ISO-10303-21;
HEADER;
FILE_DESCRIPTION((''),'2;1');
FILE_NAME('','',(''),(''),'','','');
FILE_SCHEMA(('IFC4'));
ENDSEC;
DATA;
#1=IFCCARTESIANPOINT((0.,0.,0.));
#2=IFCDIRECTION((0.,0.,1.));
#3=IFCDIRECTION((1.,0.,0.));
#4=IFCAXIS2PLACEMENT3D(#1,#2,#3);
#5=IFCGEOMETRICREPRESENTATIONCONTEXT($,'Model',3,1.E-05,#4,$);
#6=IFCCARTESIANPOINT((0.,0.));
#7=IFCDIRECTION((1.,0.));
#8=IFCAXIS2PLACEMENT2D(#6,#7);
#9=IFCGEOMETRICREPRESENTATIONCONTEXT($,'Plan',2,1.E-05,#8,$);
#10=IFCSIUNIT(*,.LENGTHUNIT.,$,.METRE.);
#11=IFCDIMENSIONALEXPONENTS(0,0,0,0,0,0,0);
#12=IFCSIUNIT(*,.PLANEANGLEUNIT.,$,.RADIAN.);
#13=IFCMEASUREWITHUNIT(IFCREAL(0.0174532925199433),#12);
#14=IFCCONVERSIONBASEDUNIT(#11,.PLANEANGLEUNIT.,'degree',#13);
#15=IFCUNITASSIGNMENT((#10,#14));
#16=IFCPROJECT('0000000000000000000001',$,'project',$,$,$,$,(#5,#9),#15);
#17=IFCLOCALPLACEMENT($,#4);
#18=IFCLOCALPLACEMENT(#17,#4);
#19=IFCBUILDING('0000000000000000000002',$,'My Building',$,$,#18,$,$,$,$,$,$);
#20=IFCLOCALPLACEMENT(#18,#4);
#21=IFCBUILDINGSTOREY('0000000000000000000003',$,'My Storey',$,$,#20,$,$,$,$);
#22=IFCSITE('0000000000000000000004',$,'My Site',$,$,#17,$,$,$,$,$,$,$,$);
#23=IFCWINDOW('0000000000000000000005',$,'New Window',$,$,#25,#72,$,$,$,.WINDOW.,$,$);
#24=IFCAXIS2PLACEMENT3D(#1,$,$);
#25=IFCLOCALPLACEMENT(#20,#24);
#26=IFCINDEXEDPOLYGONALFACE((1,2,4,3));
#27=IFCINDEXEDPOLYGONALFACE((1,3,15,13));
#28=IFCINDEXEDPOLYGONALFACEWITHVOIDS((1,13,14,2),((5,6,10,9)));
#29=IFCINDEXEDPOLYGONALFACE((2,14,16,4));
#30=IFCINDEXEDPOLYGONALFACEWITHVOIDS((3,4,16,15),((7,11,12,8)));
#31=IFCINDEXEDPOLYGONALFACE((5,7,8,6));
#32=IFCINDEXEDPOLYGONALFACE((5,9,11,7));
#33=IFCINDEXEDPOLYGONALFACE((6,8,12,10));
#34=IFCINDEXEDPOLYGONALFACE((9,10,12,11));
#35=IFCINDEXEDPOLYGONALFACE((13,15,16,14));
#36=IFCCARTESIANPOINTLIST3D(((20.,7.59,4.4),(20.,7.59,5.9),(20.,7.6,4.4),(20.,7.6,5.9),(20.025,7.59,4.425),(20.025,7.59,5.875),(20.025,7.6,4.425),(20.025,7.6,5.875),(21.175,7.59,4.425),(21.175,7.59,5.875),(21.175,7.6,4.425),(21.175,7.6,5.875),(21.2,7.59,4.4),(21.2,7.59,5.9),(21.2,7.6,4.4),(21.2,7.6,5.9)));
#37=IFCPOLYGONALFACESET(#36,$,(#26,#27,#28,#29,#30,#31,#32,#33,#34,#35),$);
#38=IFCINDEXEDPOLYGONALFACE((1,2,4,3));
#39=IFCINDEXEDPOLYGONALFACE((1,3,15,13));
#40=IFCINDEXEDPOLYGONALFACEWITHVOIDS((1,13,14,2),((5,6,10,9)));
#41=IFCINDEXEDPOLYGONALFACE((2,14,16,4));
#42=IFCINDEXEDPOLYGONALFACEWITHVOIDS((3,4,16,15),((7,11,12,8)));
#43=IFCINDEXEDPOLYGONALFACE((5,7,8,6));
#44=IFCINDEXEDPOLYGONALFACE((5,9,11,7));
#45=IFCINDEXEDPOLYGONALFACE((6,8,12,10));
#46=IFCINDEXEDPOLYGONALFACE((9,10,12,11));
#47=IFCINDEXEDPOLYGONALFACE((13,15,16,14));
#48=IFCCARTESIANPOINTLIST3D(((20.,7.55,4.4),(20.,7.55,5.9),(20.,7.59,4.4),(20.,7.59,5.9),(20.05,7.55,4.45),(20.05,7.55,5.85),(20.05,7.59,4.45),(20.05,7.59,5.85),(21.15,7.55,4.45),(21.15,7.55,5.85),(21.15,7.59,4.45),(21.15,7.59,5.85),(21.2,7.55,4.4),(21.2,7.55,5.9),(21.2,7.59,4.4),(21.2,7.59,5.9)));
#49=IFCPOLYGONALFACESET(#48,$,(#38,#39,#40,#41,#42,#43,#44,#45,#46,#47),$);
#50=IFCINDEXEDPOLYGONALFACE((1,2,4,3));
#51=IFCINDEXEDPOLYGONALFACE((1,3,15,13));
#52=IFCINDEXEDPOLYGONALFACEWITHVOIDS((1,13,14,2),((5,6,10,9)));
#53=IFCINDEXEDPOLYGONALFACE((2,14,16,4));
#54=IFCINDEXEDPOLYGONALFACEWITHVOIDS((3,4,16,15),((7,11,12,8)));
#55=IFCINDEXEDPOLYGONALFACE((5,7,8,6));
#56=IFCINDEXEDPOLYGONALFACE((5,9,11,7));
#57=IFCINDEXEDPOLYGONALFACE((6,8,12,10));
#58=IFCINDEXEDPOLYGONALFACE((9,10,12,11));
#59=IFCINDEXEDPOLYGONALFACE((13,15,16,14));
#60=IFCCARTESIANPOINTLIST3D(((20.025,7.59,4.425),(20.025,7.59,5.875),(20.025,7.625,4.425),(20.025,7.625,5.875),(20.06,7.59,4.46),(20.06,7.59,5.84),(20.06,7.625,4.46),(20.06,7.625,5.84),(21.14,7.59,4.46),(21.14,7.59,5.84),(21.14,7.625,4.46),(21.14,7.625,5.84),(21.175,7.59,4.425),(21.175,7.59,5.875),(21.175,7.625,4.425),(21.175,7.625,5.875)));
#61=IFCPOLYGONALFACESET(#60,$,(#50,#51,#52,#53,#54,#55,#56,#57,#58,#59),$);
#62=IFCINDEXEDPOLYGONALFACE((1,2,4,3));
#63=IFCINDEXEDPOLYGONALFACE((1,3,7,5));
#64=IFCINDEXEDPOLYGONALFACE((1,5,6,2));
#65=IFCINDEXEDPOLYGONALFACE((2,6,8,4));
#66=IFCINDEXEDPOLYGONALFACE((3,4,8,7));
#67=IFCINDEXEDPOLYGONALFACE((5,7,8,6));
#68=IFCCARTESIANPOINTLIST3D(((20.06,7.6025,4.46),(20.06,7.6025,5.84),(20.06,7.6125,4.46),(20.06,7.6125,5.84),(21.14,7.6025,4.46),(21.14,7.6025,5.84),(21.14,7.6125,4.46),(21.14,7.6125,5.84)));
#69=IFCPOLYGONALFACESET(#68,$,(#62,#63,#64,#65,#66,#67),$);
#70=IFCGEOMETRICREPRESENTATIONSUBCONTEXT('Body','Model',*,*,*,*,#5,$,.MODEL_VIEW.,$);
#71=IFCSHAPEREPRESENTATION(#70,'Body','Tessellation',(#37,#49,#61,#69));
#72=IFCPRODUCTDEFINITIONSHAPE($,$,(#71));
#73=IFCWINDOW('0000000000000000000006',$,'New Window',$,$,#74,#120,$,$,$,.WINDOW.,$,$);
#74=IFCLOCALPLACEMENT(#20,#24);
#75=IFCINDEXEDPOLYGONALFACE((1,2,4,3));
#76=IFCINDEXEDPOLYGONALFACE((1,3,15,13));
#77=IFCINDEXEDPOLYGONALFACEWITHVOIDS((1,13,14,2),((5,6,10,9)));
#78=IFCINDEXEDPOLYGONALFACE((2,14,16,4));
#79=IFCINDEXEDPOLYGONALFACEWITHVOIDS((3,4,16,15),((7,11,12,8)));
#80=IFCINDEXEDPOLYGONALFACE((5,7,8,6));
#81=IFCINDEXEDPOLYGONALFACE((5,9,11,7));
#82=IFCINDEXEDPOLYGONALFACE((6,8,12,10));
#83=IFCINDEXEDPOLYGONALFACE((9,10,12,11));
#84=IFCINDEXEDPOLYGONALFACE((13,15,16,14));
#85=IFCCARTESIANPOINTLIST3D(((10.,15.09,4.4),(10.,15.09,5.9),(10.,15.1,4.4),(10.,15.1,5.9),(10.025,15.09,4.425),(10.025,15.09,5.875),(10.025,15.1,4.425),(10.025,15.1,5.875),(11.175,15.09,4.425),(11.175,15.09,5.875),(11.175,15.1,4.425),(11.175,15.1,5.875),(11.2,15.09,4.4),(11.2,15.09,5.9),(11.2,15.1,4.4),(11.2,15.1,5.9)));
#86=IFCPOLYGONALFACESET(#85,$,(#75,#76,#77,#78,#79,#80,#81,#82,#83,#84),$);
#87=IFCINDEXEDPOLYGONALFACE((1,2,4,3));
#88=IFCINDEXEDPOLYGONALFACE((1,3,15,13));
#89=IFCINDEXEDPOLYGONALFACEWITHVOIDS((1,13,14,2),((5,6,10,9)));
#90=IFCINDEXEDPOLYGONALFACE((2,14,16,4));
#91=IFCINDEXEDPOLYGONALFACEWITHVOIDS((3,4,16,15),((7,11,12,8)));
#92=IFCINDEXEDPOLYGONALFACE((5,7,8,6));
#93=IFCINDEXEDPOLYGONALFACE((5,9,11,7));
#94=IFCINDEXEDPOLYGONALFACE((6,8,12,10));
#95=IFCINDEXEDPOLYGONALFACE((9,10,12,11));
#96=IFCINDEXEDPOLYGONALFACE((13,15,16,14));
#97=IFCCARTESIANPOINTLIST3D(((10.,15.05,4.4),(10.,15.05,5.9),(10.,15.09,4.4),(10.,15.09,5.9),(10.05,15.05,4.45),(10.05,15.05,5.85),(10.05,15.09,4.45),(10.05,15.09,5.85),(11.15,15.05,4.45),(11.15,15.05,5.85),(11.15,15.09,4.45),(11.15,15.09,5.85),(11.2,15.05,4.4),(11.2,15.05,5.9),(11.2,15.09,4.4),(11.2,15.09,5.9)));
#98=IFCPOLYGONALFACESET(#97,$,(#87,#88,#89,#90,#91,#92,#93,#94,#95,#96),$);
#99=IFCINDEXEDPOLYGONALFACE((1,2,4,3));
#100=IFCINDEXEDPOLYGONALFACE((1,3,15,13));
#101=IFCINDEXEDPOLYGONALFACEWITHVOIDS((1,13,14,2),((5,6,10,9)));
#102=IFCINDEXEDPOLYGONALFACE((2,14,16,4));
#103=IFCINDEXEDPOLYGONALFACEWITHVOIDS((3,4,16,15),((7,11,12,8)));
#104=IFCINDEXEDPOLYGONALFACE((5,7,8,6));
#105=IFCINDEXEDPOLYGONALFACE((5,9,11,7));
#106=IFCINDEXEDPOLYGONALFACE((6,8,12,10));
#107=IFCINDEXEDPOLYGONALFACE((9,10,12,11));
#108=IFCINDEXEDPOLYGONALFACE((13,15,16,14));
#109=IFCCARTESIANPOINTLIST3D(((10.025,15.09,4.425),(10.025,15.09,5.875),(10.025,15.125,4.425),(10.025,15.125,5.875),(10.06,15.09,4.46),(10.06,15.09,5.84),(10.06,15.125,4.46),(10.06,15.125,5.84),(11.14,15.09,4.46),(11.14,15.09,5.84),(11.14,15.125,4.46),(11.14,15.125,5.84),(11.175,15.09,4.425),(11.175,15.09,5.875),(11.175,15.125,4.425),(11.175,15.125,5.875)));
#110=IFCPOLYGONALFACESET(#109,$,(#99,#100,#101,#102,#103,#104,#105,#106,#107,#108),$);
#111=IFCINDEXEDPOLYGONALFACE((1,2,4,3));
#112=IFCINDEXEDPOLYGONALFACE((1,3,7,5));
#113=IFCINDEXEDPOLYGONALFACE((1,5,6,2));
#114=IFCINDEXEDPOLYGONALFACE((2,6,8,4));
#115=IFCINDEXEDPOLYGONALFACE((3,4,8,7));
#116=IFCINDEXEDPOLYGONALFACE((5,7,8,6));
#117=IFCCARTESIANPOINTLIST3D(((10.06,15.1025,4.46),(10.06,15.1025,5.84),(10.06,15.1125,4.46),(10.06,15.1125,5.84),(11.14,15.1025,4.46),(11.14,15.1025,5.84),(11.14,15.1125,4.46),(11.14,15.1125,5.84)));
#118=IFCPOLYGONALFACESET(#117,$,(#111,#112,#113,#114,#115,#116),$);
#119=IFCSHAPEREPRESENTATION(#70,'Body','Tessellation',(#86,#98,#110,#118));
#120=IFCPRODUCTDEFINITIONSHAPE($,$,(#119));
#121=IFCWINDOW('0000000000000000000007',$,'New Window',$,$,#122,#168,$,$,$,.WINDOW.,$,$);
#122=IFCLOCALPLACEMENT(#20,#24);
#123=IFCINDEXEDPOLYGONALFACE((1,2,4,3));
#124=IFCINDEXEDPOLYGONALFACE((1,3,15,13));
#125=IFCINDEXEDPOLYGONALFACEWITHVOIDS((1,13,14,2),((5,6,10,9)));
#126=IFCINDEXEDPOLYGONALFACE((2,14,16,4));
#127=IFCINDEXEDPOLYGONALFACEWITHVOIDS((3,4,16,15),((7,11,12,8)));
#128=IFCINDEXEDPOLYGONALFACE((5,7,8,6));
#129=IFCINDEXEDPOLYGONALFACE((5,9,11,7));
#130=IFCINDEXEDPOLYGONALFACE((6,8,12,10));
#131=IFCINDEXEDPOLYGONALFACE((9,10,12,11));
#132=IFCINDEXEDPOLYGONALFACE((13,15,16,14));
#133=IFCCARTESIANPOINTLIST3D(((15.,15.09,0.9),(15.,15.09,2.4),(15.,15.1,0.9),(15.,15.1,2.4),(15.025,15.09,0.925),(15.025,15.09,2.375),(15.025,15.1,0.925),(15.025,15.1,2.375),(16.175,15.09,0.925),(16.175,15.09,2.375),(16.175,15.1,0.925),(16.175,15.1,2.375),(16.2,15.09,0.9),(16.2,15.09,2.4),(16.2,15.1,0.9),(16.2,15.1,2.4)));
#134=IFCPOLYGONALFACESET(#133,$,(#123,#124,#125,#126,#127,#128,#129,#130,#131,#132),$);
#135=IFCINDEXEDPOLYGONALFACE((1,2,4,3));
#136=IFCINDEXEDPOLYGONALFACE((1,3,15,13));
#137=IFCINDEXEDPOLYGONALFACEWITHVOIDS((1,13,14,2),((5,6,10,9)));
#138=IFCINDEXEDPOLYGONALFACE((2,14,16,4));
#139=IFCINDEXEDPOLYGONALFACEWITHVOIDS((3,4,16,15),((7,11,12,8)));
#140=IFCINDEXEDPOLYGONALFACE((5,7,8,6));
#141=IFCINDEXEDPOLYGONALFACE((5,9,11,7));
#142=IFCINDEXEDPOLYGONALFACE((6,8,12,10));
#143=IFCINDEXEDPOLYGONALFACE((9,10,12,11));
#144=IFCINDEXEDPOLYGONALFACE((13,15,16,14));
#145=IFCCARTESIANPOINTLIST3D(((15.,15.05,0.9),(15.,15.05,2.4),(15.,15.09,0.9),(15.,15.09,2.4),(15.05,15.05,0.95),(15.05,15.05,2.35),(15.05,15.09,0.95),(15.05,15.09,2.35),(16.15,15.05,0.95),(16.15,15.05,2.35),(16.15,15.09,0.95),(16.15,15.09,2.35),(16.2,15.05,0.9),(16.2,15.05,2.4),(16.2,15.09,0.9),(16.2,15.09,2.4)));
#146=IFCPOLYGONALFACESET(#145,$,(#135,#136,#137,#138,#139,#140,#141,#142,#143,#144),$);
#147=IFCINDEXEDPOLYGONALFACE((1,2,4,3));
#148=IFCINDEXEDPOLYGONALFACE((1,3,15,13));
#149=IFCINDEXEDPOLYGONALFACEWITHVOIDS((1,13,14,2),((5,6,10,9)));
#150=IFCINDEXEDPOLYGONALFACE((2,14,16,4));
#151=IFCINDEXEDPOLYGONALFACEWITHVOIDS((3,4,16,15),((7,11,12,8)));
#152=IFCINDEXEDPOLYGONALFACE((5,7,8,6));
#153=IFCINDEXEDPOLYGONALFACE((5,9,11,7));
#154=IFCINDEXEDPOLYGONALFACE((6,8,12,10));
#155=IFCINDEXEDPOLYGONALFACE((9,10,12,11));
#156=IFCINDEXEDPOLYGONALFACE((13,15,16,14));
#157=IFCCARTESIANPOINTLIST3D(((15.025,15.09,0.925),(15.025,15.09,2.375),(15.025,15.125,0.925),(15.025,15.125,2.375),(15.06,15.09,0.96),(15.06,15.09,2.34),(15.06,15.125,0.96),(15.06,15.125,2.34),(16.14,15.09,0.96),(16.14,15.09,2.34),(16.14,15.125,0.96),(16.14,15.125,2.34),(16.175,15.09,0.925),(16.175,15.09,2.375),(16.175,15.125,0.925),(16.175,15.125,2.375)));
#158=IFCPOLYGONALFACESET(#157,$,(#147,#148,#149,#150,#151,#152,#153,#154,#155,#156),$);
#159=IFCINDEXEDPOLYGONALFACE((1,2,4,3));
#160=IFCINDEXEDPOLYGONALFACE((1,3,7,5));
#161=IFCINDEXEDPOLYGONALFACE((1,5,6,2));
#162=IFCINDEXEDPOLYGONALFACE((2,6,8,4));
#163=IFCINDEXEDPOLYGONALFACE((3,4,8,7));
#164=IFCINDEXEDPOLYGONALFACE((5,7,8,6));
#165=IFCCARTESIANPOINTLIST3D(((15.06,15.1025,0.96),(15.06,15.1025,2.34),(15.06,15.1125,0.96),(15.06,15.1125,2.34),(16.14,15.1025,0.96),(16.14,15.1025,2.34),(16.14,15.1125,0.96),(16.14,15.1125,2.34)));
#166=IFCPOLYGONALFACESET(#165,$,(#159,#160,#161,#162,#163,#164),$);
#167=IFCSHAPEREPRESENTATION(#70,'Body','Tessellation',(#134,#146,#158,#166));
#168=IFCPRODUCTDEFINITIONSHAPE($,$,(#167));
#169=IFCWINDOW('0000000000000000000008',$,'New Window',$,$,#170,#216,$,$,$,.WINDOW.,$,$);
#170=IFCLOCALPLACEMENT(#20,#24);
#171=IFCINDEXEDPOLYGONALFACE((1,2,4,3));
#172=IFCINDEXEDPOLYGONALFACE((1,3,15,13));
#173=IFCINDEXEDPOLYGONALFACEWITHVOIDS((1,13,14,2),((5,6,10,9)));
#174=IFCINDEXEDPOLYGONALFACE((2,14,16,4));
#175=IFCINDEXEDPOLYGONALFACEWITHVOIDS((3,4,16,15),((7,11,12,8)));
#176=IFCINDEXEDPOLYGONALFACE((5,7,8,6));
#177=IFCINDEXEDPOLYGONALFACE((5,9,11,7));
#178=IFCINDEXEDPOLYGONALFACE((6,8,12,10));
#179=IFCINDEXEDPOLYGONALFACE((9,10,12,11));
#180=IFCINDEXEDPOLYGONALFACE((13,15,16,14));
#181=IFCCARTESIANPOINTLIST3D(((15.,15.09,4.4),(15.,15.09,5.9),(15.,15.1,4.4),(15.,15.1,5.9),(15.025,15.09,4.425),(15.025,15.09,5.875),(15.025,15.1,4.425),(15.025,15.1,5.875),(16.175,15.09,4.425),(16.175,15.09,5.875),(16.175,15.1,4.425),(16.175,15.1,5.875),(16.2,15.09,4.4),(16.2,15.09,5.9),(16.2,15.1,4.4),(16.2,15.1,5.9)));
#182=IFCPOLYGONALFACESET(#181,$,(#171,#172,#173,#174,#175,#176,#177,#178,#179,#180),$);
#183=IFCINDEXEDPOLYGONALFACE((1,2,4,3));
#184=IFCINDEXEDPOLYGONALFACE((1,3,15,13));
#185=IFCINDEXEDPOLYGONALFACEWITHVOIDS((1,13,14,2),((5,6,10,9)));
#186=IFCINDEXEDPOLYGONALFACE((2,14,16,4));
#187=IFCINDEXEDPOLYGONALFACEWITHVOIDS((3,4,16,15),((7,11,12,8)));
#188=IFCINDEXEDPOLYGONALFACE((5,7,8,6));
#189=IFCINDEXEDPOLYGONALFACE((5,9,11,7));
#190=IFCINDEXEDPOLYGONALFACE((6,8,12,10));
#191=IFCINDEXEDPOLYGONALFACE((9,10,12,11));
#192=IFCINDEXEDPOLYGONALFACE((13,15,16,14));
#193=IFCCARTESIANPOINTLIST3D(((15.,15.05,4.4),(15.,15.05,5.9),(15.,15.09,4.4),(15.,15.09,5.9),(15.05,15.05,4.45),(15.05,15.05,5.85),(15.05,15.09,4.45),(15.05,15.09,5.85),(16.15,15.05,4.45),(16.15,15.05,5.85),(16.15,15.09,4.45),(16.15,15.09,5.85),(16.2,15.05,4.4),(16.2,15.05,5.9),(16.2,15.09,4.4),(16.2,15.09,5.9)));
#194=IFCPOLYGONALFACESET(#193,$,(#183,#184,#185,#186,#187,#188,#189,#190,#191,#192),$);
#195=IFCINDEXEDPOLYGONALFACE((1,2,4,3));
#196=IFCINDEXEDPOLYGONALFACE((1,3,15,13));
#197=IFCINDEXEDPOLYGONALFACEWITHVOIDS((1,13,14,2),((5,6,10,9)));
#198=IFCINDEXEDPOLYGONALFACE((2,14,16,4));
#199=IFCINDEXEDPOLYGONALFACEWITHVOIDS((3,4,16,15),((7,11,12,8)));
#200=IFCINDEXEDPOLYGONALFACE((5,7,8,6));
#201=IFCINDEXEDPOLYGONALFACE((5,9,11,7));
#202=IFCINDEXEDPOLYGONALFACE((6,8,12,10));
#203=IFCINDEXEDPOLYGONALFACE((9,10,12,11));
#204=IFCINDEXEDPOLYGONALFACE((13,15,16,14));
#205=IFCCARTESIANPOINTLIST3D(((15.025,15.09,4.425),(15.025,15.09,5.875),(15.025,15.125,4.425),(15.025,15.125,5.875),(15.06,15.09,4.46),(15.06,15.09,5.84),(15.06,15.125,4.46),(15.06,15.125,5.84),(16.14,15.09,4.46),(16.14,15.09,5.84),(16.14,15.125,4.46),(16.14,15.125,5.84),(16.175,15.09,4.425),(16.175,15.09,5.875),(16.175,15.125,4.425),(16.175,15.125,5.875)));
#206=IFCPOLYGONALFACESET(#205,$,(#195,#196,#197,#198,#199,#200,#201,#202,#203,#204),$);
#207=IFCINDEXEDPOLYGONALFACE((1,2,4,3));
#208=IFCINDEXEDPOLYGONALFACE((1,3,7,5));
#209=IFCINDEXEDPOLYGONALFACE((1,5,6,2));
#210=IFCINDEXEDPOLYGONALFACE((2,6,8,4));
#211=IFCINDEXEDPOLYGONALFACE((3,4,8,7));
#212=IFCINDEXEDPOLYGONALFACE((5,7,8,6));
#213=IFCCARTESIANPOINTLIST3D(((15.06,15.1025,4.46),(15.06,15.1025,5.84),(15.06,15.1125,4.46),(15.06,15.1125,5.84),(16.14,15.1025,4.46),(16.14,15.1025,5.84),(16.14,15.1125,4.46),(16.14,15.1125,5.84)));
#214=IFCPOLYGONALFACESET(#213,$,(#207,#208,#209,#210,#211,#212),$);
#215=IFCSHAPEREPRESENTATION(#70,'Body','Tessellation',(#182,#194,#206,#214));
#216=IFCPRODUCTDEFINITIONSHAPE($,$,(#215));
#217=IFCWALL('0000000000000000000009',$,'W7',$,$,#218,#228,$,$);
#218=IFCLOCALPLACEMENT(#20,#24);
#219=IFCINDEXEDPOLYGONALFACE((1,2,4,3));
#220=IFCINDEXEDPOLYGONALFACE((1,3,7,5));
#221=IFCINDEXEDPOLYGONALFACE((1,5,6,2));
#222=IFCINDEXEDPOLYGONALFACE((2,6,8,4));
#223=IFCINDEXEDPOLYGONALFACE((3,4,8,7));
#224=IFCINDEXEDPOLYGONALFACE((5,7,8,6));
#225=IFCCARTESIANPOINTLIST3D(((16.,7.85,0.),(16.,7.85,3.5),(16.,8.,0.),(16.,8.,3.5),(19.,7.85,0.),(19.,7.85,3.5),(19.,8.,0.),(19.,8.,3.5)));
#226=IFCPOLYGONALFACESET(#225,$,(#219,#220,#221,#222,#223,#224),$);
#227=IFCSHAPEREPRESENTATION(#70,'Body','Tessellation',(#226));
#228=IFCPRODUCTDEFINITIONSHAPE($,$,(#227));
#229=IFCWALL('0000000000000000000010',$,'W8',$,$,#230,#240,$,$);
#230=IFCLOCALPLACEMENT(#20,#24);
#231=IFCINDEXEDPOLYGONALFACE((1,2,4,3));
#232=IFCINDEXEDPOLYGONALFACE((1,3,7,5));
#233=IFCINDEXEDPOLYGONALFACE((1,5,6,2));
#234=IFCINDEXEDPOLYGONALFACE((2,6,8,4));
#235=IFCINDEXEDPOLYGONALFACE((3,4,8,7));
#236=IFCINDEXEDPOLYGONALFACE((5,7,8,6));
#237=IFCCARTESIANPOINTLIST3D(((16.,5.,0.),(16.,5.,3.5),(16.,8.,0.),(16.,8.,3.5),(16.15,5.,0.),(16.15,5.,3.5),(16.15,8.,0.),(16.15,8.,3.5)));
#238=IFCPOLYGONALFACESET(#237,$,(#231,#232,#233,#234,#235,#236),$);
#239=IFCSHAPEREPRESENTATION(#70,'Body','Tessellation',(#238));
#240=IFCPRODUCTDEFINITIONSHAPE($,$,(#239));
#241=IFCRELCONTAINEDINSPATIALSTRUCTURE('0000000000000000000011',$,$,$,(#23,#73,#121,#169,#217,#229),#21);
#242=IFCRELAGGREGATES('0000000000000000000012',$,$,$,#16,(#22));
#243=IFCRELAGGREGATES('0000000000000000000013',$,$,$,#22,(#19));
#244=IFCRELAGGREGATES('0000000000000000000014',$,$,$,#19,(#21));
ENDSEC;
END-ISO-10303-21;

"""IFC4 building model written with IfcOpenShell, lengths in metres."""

from ifc_helpers import new_model, entity, si_unit, converted_unit, frame, origin_with_axes, origin_2d_with_axis, place, context, subcontext, project, spatial, line, indexed_curve, outline, extrude, element, save


model = new_model("IFC4")

# Units and contexts
model_context = context("Model", 3, precision=1e-05, world=origin_with_axes())
plan_context = context("Plan", 2, precision=1e-05, world=origin_2d_with_axis())
body_context = subcontext(model_context, "Body", "Model", "MODEL_VIEW")
ifc_project = project(units=[si_unit("LENGTHUNIT", "METRE"), converted_unit("PLANEANGLEUNIT", "degree", entity("IfcReal", 0.0174532925199433), si_unit("PLANEANGLEUNIT", "RADIAN"), dimensions=[0, 0, 0, 0, 0, 0, 0])], contexts=[model_context, plan_context])

# Site, building, storey
site_placement = place(None, origin_with_axes())
site = spatial("IfcSite", under=ifc_project, at=site_placement, Name="My Site")
building_placement = place(site_placement, origin_with_axes())
building = spatial("IfcBuilding", under=site, at=building_placement, Name="My Building")
storey_placement = place(building_placement, origin_with_axes())
storey = spatial("IfcBuildingStorey", under=building, at=storey_placement, Name="My Storey")

# Windows
for number, where, z_axis, x_axis, name in (
    (1, (20.0, 7.5, 4.4), (0.0, 0.0, 1.0), (1.0, 0.0, 0.0), "New Window"),
    (2, (10.0, 15.0, 4.4), (0.0, 0.0, 1.0), (1.0, 0.0, 0.0), "New Window"),
    (3, (15.0, 15.0, 0.9), (0.0, 0.0, 1.0), (1.0, 0.0, 0.0), "New Window"),
    (4, (15.0, 15.0, 4.4), (0.0, 0.0, 1.0), (1.0, 0.0, 0.0), "New Window"),
):
    element("IfcWindow", number, at=place(storey_placement, frame(where, z_axis=z_axis, x_axis=x_axis)), inside=storey, Name=name, PredefinedType="WINDOW", context=body_context, shape_type="SweptSolid", body=[
        extrude(outline(indexed_curve([(0.0, 0.0), (1.2, 0.0), (1.2, 1.5), (0.0, 1.5)], segments=[line(1, 2, 3, 4, 1)]), holes=[indexed_curve([(0.025, 0.025), (1.175, 0.025), (1.175, 1.475), (0.025, 1.475)], segments=[line(1, 2, 3, 4, 1)])]), frame((0.0, 0.09, 0.0), z_axis=(0.0, -1.0, 0.0), x_axis=(1.0, 0.0, 0.0)), (0.0, 0.0, -1.0), 0.01),
        extrude(outline(indexed_curve([(0.0, 0.0), (1.2, 0.0), (1.2, 1.5), (0.0, 1.5)], segments=[line(1, 2, 3, 4, 1)]), holes=[indexed_curve([(0.05, 0.05), (1.15, 0.05), (1.15, 1.45), (0.05, 1.45)], segments=[line(1, 2, 3, 4, 1)])]), frame((0.0, 0.05, 0.0), z_axis=(0.0, -1.0, 0.0), x_axis=(1.0, 0.0, 0.0)), (0.0, 0.0, -1.0), 0.04),
        extrude(outline(indexed_curve([(0.0, 0.0), (1.15, 0.0), (1.15, 1.45), (0.0, 1.45)], segments=[line(1, 2, 3, 4, 1)]), holes=[indexed_curve([(0.035, 0.035), (1.115, 0.035), (1.115, 1.415), (0.035, 1.415)], segments=[line(1, 2, 3, 4, 1)])]), frame((0.025, 0.09, 0.025), z_axis=(0.0, -1.0, 0.0), x_axis=(1.0, 0.0, 0.0)), (0.0, 0.0, -1.0), 0.035),
        extrude(outline(indexed_curve([(0.035, 0.035), (1.115, 0.035), (1.115, 1.415), (0.035, 1.415)], segments=[line(1, 2, 3, 4, 1)])), frame((0.025, 0.1025, 0.025), z_axis=(0.0, -1.0, 0.0), x_axis=(1.0, 0.0, 0.0)), (0.0, 0.0, -1.0), 0.01),
    ])

# Walls
for number, where, z_axis, x_axis, name in (
    (5, (19.0, 8.0, 0.0), (0.0, 0.0, 1.0), (-1.0, 0.0, 0.0), "W7"),
    (6, (16.0, 8.0, 0.0), (0.0, 0.0, 1.0), (0.0, -1.0, 0.0), "W8"),
):
    element("IfcWall", number, at=place(storey_placement, frame(where, z_axis=z_axis, x_axis=x_axis)), inside=storey, Name=name, context=body_context, shape_type="SweptSolid", body=[
        extrude(outline(indexed_curve([(0.0, 0.0), (0.0, 0.15), (3.0, 0.15), (3.0, 0.0), (0.0, 0.0)], self_intersect=False)), origin_with_axes(), (0.0, 0.0, 1.0), 3.5),
    ])

save(model, "model.ifc")
